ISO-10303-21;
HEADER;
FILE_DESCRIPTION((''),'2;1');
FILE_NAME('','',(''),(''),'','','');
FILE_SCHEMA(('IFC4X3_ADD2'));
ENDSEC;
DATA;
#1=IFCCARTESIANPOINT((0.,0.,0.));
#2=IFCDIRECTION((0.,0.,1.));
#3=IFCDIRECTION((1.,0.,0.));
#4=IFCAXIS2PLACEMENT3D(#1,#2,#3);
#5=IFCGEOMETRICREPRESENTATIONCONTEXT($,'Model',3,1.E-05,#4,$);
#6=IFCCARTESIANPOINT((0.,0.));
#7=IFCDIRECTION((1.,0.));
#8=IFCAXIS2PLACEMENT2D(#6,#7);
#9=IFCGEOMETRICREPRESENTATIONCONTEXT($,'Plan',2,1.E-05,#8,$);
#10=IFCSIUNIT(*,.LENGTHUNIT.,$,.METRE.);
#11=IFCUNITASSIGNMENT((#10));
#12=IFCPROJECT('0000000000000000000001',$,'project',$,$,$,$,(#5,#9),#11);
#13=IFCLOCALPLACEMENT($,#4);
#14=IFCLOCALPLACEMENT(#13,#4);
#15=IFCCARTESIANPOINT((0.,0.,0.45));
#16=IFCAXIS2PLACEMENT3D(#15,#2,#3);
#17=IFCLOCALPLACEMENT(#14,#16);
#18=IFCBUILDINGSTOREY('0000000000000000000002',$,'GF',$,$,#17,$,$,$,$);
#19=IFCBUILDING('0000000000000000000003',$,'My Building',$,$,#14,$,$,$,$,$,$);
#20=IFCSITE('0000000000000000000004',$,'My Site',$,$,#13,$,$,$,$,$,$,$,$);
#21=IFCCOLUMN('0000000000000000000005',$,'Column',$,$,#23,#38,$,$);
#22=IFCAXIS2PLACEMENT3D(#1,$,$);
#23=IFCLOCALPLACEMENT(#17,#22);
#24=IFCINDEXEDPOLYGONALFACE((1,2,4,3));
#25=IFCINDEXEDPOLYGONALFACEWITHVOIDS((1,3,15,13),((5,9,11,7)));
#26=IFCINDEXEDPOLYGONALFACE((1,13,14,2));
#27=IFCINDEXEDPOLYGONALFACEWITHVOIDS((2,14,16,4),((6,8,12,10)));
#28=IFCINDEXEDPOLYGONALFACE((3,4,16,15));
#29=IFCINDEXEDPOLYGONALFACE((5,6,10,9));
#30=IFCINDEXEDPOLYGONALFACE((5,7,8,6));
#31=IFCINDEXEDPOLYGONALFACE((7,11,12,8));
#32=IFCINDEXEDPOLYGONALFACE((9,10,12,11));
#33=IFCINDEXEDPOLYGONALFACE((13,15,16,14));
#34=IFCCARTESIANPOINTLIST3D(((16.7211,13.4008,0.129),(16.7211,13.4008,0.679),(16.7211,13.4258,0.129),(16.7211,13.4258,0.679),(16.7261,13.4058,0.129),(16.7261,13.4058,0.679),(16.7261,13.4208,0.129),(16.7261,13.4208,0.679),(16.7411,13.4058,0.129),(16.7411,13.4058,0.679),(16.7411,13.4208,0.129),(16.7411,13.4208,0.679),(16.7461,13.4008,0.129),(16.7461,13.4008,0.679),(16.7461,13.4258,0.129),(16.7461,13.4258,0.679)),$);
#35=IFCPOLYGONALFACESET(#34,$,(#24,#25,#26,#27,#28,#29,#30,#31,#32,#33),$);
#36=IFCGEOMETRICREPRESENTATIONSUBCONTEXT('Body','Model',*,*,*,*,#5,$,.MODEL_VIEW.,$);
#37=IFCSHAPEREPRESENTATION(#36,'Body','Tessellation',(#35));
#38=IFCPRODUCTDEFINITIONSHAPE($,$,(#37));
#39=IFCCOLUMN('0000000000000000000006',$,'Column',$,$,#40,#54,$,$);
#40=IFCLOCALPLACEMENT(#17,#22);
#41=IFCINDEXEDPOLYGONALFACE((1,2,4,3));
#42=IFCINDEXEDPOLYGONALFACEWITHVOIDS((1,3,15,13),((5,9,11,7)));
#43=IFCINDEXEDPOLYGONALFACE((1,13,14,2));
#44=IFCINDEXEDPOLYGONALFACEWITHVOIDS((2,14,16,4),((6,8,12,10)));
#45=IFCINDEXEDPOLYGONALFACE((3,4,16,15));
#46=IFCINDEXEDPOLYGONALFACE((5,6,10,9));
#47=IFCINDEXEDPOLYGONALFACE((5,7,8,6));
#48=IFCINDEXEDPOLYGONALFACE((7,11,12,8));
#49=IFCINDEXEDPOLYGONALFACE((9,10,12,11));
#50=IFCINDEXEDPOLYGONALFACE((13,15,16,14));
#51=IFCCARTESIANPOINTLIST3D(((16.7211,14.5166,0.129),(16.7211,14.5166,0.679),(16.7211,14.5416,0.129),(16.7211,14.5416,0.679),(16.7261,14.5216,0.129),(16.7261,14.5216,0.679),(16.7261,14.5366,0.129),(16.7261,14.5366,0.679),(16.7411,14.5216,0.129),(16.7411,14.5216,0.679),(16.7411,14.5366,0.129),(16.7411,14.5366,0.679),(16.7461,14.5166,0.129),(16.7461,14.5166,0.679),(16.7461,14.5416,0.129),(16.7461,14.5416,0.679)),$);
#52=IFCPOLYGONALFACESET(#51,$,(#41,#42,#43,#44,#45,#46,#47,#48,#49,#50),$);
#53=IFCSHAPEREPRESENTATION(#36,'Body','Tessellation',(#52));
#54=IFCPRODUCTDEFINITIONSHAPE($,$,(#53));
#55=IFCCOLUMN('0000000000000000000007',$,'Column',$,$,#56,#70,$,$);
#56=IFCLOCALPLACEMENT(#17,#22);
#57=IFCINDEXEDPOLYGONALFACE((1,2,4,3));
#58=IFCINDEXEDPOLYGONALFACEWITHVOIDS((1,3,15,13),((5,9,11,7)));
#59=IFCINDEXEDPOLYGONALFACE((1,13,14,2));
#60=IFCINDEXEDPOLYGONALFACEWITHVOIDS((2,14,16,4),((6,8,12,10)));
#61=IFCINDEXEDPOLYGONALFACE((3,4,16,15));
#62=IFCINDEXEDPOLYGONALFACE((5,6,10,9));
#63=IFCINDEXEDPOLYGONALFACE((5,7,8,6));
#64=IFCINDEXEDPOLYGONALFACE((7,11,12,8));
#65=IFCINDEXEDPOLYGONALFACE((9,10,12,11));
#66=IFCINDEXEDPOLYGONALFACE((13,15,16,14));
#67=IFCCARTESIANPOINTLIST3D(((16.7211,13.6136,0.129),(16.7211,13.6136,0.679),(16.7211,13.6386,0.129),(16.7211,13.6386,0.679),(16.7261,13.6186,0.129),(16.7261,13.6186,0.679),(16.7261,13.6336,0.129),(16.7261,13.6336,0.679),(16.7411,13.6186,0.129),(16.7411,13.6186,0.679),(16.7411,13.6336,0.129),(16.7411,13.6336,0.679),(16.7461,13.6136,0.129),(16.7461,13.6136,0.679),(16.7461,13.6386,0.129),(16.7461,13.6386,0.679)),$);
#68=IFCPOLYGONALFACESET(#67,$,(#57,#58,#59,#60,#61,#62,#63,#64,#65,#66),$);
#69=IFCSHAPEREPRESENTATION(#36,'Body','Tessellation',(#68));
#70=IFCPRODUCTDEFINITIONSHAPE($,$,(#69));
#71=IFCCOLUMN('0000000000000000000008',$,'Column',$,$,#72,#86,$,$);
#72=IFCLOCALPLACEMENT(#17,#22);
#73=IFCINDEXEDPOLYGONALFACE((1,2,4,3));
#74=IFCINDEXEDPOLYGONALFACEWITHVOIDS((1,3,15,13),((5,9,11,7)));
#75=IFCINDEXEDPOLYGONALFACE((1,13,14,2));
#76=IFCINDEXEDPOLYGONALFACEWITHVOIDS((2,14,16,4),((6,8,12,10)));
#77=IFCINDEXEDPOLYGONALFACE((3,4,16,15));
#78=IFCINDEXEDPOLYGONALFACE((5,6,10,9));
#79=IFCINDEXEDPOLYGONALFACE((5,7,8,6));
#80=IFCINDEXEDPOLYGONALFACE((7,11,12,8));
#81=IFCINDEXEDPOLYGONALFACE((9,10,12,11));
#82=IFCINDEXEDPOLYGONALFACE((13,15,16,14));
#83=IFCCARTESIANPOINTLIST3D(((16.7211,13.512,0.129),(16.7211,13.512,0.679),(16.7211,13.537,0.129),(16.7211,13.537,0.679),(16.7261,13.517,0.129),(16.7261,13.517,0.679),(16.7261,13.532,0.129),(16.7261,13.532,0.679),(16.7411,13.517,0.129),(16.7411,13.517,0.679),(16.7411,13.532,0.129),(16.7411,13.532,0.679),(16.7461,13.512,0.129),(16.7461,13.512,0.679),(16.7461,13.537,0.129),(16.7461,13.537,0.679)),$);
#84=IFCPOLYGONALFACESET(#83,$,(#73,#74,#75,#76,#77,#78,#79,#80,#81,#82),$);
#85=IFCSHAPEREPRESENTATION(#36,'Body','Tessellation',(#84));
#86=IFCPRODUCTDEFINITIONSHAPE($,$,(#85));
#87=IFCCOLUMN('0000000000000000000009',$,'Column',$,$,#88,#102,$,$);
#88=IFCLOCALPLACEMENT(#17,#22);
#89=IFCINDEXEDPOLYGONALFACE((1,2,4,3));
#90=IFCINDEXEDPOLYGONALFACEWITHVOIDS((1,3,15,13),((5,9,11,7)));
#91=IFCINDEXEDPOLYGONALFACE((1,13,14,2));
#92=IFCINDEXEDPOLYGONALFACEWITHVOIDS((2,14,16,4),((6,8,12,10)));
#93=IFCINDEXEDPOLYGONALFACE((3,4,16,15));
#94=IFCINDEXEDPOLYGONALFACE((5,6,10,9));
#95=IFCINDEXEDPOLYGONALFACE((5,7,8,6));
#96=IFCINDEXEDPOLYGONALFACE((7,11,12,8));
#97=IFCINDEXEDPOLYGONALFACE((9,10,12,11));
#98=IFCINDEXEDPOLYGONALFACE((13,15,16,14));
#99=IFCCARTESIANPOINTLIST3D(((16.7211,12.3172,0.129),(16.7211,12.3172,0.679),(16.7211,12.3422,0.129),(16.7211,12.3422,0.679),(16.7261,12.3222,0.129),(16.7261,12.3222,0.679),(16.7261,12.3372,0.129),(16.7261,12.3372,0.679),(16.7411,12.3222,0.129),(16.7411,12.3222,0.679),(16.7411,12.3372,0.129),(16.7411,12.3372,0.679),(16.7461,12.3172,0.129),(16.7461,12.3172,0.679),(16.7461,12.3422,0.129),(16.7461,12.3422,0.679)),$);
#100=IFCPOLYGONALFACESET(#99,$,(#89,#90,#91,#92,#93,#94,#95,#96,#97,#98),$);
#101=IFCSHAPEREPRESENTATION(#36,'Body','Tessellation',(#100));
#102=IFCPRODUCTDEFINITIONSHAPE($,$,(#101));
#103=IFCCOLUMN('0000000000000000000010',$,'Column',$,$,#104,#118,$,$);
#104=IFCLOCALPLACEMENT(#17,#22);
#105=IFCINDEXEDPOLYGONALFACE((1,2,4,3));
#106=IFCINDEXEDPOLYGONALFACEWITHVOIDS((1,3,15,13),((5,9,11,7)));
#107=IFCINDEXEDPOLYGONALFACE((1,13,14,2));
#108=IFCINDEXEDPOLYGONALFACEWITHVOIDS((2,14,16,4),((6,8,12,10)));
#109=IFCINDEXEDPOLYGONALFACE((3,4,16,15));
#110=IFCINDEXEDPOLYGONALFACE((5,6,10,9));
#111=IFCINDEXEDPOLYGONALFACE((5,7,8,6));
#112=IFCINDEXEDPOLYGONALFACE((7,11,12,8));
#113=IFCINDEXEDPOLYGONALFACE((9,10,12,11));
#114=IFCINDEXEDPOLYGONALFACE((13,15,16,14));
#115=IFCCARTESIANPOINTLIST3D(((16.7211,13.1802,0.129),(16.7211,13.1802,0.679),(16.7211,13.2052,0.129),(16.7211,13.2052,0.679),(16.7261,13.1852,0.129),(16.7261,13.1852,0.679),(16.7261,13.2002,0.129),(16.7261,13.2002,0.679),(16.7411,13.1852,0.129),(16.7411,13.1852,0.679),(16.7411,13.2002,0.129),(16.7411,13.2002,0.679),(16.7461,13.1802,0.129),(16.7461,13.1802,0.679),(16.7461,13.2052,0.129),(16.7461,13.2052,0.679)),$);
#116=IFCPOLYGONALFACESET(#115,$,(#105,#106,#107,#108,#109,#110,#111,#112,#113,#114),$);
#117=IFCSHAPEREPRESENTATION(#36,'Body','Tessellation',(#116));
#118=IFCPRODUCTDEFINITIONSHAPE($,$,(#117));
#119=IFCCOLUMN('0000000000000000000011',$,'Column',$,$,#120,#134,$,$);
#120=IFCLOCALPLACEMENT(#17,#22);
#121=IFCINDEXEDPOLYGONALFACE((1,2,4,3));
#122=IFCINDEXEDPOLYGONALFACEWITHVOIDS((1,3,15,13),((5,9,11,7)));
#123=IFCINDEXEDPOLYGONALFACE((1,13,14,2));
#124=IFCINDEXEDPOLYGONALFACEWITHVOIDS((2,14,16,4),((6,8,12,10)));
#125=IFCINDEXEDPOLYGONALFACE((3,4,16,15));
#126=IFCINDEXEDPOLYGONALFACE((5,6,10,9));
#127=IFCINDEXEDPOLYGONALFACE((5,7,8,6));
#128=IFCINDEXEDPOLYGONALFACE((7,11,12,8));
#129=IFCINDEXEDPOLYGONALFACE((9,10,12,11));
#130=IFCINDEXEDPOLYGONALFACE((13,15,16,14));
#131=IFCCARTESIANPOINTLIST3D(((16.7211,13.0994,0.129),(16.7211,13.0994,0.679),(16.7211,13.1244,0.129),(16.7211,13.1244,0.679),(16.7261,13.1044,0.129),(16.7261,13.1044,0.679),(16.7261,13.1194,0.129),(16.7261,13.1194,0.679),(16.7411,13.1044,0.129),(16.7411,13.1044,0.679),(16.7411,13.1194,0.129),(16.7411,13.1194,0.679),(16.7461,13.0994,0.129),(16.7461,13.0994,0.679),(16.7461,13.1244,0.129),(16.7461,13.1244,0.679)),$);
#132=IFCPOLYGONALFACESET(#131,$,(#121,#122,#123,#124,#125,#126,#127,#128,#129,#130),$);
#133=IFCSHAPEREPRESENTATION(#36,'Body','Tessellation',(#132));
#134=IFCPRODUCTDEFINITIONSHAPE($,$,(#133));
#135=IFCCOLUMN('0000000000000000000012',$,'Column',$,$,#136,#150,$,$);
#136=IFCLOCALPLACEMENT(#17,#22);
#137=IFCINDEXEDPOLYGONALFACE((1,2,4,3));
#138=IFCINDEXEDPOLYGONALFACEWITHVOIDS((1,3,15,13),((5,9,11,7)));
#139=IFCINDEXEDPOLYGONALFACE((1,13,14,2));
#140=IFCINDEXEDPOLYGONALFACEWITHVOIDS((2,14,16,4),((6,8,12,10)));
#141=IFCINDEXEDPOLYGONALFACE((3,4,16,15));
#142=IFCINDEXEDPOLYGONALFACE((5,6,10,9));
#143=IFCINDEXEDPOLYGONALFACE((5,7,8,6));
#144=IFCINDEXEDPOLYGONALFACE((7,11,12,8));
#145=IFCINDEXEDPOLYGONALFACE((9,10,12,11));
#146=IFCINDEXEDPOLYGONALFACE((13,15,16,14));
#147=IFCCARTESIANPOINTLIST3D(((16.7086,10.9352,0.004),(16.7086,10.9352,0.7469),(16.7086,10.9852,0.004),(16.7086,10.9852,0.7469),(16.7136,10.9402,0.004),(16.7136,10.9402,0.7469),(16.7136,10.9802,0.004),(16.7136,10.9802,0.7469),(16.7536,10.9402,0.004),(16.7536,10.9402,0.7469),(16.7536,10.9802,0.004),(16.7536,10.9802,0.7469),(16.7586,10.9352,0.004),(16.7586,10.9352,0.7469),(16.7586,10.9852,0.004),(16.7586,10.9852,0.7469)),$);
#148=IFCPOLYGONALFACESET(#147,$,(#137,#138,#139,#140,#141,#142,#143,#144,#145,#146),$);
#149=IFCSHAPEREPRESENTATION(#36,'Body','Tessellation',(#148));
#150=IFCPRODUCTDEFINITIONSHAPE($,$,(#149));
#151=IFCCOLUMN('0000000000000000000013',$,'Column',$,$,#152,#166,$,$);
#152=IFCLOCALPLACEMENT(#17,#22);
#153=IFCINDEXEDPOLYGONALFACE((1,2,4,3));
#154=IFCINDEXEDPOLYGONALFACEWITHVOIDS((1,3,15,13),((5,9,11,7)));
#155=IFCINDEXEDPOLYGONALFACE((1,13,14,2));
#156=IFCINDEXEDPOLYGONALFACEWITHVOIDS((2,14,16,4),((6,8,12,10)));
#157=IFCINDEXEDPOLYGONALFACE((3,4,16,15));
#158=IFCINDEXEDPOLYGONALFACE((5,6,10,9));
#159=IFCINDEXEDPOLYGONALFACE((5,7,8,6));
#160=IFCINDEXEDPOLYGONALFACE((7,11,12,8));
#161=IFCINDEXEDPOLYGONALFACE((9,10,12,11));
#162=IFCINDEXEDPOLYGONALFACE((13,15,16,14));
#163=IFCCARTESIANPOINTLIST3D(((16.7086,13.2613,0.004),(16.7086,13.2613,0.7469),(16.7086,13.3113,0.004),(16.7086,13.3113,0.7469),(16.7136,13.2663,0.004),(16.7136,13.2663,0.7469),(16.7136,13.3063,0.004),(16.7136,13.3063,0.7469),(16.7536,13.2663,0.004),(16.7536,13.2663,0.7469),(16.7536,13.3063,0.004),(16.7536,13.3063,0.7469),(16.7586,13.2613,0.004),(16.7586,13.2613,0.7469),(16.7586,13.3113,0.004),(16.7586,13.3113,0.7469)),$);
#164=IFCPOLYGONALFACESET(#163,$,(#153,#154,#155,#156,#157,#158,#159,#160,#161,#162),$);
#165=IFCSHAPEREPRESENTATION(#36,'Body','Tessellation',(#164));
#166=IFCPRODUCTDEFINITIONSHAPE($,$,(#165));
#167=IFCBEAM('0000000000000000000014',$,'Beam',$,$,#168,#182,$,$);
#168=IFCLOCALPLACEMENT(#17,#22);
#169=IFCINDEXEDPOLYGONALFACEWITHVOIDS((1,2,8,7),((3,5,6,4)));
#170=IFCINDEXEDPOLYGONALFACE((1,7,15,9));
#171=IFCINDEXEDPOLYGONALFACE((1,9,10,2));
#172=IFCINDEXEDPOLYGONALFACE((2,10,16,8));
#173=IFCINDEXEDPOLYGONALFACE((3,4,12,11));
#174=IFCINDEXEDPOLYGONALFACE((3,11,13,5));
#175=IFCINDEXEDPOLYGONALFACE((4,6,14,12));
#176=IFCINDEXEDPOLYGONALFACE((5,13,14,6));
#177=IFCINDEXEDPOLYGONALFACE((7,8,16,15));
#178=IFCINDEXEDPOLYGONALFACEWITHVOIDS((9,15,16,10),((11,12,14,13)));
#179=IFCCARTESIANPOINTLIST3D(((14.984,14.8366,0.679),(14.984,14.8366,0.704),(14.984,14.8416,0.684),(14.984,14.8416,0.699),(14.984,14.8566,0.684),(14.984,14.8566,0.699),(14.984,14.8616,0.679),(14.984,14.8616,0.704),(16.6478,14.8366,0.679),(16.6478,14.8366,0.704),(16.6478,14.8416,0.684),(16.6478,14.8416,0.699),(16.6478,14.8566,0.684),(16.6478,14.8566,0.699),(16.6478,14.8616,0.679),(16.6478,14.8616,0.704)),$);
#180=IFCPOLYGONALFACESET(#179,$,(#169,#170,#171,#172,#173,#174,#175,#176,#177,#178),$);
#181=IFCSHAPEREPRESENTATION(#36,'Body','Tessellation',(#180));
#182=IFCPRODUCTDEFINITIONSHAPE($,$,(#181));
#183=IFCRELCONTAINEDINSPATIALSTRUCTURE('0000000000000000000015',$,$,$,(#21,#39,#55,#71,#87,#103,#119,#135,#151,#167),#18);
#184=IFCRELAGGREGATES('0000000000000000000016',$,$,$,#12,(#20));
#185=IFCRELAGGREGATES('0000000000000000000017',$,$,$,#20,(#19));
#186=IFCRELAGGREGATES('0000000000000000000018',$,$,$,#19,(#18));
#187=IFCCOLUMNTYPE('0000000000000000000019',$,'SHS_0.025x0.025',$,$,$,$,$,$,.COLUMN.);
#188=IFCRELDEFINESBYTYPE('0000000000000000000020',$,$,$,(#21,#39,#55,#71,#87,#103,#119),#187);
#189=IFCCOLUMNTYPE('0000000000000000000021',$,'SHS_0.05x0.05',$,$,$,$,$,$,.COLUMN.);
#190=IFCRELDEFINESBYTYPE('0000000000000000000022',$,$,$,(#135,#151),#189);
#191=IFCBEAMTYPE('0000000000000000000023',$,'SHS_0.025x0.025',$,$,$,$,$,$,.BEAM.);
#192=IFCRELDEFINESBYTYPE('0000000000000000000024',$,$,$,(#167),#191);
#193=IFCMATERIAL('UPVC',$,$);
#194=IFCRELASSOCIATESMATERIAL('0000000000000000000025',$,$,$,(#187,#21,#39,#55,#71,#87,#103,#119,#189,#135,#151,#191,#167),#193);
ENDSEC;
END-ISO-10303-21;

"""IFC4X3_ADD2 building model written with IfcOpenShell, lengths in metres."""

from ifc_helpers import new_model, si_unit, frame, origin_with_axes, origin_2d_with_axis, place, context, subcontext, project, spatial, hollow_rectangle, extrude, material, material_profile, profile_set, profile_usage, type_object, element, save


model = new_model("IFC4X3_ADD2")

# Units and contexts
model_context = context("Model", 3, precision=1e-05, world=origin_with_axes())
plan_context = context("Plan", 2, precision=1e-05, world=origin_2d_with_axis())
body_context = subcontext(model_context, "Body", "Model", "MODEL_VIEW")
ifc_project = project(units=[si_unit("LENGTHUNIT", "METRE")], contexts=[model_context, plan_context])

# Site, building, storey
site_placement = place(None, origin_with_axes())
site = spatial("IfcSite", under=ifc_project, at=site_placement, Name="My Site")
building_placement = place(site_placement, origin_with_axes())
building = spatial("IfcBuilding", under=site, at=building_placement, Name="My Building")
storey_placement = place(building_placement, frame((0.0, 0.0, 0.45), z_axis=(0.0, 0.0, 1.0), x_axis=(1.0, 0.0, 0.0)))
storey = spatial("IfcBuildingStorey", under=building, at=storey_placement, Name="GF")

# Columns
ifc_material_1 = material(Name="UPVC")
ifc_material_profile_1 = material_profile(ifc_material_1, hollow_rectangle(XDim=0.025, YDim=0.025, WallThickness=0.005))
ifc_profile_set_1 = profile_set([ifc_material_profile_1])
column_type_1 = type_object("IfcColumnType", Name="SHS_0.025x0.025", PredefinedType="COLUMN", material=ifc_profile_set_1)
ifc_profile_usage_1 = profile_usage(ifc_profile_set_1)
column_1_placement = place(storey_placement, frame((16.7336, 13.4133, 0.129), z_axis=(0.0, 0.0, 1.0), x_axis=(0.0, -1.0, 0.0)))
element("IfcColumn", 1, at=column_1_placement, inside=storey, type_object=column_type_1, material=ifc_profile_usage_1, Name="Column", context=body_context, shape_type="SweptSolid", body=[
    extrude(hollow_rectangle(XDim=0.025, YDim=0.025, WallThickness=0.005), origin_with_axes(), (0.0, 0.0, 1.0), 0.55),
])
ifc_profile_usage_2 = profile_usage(ifc_profile_set_1)
column_2_placement = place(storey_placement, frame((16.7336, 14.5291, 0.129), z_axis=(0.0, 0.0, 1.0), x_axis=(0.0, -1.0, 0.0)))
element("IfcColumn", 2, at=column_2_placement, inside=storey, type_object=column_type_1, material=ifc_profile_usage_2, Name="Column", context=body_context, shape_type="SweptSolid", body=[
    extrude(hollow_rectangle(XDim=0.025, YDim=0.025, WallThickness=0.005), origin_with_axes(), (0.0, 0.0, 1.0), 0.55),
])
ifc_profile_usage_3 = profile_usage(ifc_profile_set_1)
column_3_placement = place(storey_placement, frame((16.7336, 13.6261, 0.129), z_axis=(0.0, 0.0, 1.0), x_axis=(0.0, -1.0, 0.0)))
element("IfcColumn", 3, at=column_3_placement, inside=storey, type_object=column_type_1, material=ifc_profile_usage_3, Name="Column", context=body_context, shape_type="SweptSolid", body=[
    extrude(hollow_rectangle(XDim=0.025, YDim=0.025, WallThickness=0.005), origin_with_axes(), (0.0, 0.0, 1.0), 0.55),
])
ifc_profile_usage_4 = profile_usage(ifc_profile_set_1)
column_4_placement = place(storey_placement, frame((16.7336, 13.5245, 0.129), z_axis=(0.0, 0.0, 1.0), x_axis=(0.0, -1.0, 0.0)))
element("IfcColumn", 4, at=column_4_placement, inside=storey, type_object=column_type_1, material=ifc_profile_usage_4, Name="Column", context=body_context, shape_type="SweptSolid", body=[
    extrude(hollow_rectangle(XDim=0.025, YDim=0.025, WallThickness=0.005), origin_with_axes(), (0.0, 0.0, 1.0), 0.55),
])
ifc_profile_usage_5 = profile_usage(ifc_profile_set_1)
column_5_placement = place(storey_placement, frame((16.7336, 12.3297, 0.129), z_axis=(0.0, 0.0, 1.0), x_axis=(0.0, -1.0, 0.0)))
element("IfcColumn", 5, at=column_5_placement, inside=storey, type_object=column_type_1, material=ifc_profile_usage_5, Name="Column", context=body_context, shape_type="SweptSolid", body=[
    extrude(hollow_rectangle(XDim=0.025, YDim=0.025, WallThickness=0.005), origin_with_axes(), (0.0, 0.0, 1.0), 0.55),
])
ifc_profile_usage_6 = profile_usage(ifc_profile_set_1)
column_6_placement = place(storey_placement, frame((16.7336, 13.1927, 0.129), z_axis=(0.0, 0.0, 1.0), x_axis=(0.0, -1.0, 0.0)))
element("IfcColumn", 6, at=column_6_placement, inside=storey, type_object=column_type_1, material=ifc_profile_usage_6, Name="Column", context=body_context, shape_type="SweptSolid", body=[
    extrude(hollow_rectangle(XDim=0.025, YDim=0.025, WallThickness=0.005), origin_with_axes(), (0.0, 0.0, 1.0), 0.55),
])
ifc_profile_usage_7 = profile_usage(ifc_profile_set_1)
column_7_placement = place(storey_placement, frame((16.7336, 13.1119, 0.129), z_axis=(0.0, 0.0, 1.0), x_axis=(0.0, -1.0, 0.0)))
element("IfcColumn", 7, at=column_7_placement, inside=storey, type_object=column_type_1, material=ifc_profile_usage_7, Name="Column", context=body_context, shape_type="SweptSolid", body=[
    extrude(hollow_rectangle(XDim=0.025, YDim=0.025, WallThickness=0.005), origin_with_axes(), (0.0, 0.0, 1.0), 0.55),
])
ifc_material_profile_2 = material_profile(ifc_material_1, hollow_rectangle(XDim=0.05, YDim=0.05, WallThickness=0.005))
ifc_profile_set_2 = profile_set([ifc_material_profile_2])
ifc_profile_usage_8 = profile_usage(ifc_profile_set_2)
column_type_2 = type_object("IfcColumnType", Name="SHS_0.05x0.05", PredefinedType="COLUMN", material=ifc_profile_set_2)
column_8_placement = place(storey_placement, frame((16.7336, 10.9602, 0.004), z_axis=(0.0, 0.0, 1.0), x_axis=(0.0, -1.0, 0.0)))
element("IfcColumn", 8, at=column_8_placement, inside=storey, type_object=column_type_2, material=ifc_profile_usage_8, Name="Column", context=body_context, shape_type="SweptSolid", body=[
    extrude(hollow_rectangle(XDim=0.05, YDim=0.05, WallThickness=0.005), origin_with_axes(), (0.0, 0.0, 1.0), 0.7429),
])
ifc_profile_usage_9 = profile_usage(ifc_profile_set_2)
column_9_placement = place(storey_placement, frame((16.7336, 13.2863, 0.004), z_axis=(0.0, 0.0, 1.0), x_axis=(0.0, -1.0, 0.0)))
element("IfcColumn", 9, at=column_9_placement, inside=storey, type_object=column_type_2, material=ifc_profile_usage_9, Name="Column", context=body_context, shape_type="SweptSolid", body=[
    extrude(hollow_rectangle(XDim=0.05, YDim=0.05, WallThickness=0.005), origin_with_axes(), (0.0, 0.0, 1.0), 0.7429),
])

# Beam
ifc_material_profile_3 = material_profile(ifc_material_1, hollow_rectangle(XDim=0.025, YDim=0.025, WallThickness=0.005))
ifc_profile_set_3 = profile_set([ifc_material_profile_3])
ifc_profile_usage_10 = profile_usage(ifc_profile_set_3)
beam_type_1 = type_object("IfcBeamType", Name="SHS_0.025x0.025", PredefinedType="BEAM", material=ifc_profile_set_3)
beam_1_placement = place(storey_placement, frame((14.984, 14.8491, 0.6915), z_axis=(1.0, 0.0, 0.0), x_axis=(0.0, 1.0, 0.0)))
element("IfcBeam", 10, at=beam_1_placement, inside=storey, type_object=beam_type_1, material=ifc_profile_usage_10, Name="Beam", context=body_context, shape_type="SweptSolid", body=[
    extrude(hollow_rectangle(XDim=0.025, YDim=0.025, WallThickness=0.005), origin_with_axes(), (0.0, 0.0, 1.0), 1.6638),
])

save(model, "model.ifc")
